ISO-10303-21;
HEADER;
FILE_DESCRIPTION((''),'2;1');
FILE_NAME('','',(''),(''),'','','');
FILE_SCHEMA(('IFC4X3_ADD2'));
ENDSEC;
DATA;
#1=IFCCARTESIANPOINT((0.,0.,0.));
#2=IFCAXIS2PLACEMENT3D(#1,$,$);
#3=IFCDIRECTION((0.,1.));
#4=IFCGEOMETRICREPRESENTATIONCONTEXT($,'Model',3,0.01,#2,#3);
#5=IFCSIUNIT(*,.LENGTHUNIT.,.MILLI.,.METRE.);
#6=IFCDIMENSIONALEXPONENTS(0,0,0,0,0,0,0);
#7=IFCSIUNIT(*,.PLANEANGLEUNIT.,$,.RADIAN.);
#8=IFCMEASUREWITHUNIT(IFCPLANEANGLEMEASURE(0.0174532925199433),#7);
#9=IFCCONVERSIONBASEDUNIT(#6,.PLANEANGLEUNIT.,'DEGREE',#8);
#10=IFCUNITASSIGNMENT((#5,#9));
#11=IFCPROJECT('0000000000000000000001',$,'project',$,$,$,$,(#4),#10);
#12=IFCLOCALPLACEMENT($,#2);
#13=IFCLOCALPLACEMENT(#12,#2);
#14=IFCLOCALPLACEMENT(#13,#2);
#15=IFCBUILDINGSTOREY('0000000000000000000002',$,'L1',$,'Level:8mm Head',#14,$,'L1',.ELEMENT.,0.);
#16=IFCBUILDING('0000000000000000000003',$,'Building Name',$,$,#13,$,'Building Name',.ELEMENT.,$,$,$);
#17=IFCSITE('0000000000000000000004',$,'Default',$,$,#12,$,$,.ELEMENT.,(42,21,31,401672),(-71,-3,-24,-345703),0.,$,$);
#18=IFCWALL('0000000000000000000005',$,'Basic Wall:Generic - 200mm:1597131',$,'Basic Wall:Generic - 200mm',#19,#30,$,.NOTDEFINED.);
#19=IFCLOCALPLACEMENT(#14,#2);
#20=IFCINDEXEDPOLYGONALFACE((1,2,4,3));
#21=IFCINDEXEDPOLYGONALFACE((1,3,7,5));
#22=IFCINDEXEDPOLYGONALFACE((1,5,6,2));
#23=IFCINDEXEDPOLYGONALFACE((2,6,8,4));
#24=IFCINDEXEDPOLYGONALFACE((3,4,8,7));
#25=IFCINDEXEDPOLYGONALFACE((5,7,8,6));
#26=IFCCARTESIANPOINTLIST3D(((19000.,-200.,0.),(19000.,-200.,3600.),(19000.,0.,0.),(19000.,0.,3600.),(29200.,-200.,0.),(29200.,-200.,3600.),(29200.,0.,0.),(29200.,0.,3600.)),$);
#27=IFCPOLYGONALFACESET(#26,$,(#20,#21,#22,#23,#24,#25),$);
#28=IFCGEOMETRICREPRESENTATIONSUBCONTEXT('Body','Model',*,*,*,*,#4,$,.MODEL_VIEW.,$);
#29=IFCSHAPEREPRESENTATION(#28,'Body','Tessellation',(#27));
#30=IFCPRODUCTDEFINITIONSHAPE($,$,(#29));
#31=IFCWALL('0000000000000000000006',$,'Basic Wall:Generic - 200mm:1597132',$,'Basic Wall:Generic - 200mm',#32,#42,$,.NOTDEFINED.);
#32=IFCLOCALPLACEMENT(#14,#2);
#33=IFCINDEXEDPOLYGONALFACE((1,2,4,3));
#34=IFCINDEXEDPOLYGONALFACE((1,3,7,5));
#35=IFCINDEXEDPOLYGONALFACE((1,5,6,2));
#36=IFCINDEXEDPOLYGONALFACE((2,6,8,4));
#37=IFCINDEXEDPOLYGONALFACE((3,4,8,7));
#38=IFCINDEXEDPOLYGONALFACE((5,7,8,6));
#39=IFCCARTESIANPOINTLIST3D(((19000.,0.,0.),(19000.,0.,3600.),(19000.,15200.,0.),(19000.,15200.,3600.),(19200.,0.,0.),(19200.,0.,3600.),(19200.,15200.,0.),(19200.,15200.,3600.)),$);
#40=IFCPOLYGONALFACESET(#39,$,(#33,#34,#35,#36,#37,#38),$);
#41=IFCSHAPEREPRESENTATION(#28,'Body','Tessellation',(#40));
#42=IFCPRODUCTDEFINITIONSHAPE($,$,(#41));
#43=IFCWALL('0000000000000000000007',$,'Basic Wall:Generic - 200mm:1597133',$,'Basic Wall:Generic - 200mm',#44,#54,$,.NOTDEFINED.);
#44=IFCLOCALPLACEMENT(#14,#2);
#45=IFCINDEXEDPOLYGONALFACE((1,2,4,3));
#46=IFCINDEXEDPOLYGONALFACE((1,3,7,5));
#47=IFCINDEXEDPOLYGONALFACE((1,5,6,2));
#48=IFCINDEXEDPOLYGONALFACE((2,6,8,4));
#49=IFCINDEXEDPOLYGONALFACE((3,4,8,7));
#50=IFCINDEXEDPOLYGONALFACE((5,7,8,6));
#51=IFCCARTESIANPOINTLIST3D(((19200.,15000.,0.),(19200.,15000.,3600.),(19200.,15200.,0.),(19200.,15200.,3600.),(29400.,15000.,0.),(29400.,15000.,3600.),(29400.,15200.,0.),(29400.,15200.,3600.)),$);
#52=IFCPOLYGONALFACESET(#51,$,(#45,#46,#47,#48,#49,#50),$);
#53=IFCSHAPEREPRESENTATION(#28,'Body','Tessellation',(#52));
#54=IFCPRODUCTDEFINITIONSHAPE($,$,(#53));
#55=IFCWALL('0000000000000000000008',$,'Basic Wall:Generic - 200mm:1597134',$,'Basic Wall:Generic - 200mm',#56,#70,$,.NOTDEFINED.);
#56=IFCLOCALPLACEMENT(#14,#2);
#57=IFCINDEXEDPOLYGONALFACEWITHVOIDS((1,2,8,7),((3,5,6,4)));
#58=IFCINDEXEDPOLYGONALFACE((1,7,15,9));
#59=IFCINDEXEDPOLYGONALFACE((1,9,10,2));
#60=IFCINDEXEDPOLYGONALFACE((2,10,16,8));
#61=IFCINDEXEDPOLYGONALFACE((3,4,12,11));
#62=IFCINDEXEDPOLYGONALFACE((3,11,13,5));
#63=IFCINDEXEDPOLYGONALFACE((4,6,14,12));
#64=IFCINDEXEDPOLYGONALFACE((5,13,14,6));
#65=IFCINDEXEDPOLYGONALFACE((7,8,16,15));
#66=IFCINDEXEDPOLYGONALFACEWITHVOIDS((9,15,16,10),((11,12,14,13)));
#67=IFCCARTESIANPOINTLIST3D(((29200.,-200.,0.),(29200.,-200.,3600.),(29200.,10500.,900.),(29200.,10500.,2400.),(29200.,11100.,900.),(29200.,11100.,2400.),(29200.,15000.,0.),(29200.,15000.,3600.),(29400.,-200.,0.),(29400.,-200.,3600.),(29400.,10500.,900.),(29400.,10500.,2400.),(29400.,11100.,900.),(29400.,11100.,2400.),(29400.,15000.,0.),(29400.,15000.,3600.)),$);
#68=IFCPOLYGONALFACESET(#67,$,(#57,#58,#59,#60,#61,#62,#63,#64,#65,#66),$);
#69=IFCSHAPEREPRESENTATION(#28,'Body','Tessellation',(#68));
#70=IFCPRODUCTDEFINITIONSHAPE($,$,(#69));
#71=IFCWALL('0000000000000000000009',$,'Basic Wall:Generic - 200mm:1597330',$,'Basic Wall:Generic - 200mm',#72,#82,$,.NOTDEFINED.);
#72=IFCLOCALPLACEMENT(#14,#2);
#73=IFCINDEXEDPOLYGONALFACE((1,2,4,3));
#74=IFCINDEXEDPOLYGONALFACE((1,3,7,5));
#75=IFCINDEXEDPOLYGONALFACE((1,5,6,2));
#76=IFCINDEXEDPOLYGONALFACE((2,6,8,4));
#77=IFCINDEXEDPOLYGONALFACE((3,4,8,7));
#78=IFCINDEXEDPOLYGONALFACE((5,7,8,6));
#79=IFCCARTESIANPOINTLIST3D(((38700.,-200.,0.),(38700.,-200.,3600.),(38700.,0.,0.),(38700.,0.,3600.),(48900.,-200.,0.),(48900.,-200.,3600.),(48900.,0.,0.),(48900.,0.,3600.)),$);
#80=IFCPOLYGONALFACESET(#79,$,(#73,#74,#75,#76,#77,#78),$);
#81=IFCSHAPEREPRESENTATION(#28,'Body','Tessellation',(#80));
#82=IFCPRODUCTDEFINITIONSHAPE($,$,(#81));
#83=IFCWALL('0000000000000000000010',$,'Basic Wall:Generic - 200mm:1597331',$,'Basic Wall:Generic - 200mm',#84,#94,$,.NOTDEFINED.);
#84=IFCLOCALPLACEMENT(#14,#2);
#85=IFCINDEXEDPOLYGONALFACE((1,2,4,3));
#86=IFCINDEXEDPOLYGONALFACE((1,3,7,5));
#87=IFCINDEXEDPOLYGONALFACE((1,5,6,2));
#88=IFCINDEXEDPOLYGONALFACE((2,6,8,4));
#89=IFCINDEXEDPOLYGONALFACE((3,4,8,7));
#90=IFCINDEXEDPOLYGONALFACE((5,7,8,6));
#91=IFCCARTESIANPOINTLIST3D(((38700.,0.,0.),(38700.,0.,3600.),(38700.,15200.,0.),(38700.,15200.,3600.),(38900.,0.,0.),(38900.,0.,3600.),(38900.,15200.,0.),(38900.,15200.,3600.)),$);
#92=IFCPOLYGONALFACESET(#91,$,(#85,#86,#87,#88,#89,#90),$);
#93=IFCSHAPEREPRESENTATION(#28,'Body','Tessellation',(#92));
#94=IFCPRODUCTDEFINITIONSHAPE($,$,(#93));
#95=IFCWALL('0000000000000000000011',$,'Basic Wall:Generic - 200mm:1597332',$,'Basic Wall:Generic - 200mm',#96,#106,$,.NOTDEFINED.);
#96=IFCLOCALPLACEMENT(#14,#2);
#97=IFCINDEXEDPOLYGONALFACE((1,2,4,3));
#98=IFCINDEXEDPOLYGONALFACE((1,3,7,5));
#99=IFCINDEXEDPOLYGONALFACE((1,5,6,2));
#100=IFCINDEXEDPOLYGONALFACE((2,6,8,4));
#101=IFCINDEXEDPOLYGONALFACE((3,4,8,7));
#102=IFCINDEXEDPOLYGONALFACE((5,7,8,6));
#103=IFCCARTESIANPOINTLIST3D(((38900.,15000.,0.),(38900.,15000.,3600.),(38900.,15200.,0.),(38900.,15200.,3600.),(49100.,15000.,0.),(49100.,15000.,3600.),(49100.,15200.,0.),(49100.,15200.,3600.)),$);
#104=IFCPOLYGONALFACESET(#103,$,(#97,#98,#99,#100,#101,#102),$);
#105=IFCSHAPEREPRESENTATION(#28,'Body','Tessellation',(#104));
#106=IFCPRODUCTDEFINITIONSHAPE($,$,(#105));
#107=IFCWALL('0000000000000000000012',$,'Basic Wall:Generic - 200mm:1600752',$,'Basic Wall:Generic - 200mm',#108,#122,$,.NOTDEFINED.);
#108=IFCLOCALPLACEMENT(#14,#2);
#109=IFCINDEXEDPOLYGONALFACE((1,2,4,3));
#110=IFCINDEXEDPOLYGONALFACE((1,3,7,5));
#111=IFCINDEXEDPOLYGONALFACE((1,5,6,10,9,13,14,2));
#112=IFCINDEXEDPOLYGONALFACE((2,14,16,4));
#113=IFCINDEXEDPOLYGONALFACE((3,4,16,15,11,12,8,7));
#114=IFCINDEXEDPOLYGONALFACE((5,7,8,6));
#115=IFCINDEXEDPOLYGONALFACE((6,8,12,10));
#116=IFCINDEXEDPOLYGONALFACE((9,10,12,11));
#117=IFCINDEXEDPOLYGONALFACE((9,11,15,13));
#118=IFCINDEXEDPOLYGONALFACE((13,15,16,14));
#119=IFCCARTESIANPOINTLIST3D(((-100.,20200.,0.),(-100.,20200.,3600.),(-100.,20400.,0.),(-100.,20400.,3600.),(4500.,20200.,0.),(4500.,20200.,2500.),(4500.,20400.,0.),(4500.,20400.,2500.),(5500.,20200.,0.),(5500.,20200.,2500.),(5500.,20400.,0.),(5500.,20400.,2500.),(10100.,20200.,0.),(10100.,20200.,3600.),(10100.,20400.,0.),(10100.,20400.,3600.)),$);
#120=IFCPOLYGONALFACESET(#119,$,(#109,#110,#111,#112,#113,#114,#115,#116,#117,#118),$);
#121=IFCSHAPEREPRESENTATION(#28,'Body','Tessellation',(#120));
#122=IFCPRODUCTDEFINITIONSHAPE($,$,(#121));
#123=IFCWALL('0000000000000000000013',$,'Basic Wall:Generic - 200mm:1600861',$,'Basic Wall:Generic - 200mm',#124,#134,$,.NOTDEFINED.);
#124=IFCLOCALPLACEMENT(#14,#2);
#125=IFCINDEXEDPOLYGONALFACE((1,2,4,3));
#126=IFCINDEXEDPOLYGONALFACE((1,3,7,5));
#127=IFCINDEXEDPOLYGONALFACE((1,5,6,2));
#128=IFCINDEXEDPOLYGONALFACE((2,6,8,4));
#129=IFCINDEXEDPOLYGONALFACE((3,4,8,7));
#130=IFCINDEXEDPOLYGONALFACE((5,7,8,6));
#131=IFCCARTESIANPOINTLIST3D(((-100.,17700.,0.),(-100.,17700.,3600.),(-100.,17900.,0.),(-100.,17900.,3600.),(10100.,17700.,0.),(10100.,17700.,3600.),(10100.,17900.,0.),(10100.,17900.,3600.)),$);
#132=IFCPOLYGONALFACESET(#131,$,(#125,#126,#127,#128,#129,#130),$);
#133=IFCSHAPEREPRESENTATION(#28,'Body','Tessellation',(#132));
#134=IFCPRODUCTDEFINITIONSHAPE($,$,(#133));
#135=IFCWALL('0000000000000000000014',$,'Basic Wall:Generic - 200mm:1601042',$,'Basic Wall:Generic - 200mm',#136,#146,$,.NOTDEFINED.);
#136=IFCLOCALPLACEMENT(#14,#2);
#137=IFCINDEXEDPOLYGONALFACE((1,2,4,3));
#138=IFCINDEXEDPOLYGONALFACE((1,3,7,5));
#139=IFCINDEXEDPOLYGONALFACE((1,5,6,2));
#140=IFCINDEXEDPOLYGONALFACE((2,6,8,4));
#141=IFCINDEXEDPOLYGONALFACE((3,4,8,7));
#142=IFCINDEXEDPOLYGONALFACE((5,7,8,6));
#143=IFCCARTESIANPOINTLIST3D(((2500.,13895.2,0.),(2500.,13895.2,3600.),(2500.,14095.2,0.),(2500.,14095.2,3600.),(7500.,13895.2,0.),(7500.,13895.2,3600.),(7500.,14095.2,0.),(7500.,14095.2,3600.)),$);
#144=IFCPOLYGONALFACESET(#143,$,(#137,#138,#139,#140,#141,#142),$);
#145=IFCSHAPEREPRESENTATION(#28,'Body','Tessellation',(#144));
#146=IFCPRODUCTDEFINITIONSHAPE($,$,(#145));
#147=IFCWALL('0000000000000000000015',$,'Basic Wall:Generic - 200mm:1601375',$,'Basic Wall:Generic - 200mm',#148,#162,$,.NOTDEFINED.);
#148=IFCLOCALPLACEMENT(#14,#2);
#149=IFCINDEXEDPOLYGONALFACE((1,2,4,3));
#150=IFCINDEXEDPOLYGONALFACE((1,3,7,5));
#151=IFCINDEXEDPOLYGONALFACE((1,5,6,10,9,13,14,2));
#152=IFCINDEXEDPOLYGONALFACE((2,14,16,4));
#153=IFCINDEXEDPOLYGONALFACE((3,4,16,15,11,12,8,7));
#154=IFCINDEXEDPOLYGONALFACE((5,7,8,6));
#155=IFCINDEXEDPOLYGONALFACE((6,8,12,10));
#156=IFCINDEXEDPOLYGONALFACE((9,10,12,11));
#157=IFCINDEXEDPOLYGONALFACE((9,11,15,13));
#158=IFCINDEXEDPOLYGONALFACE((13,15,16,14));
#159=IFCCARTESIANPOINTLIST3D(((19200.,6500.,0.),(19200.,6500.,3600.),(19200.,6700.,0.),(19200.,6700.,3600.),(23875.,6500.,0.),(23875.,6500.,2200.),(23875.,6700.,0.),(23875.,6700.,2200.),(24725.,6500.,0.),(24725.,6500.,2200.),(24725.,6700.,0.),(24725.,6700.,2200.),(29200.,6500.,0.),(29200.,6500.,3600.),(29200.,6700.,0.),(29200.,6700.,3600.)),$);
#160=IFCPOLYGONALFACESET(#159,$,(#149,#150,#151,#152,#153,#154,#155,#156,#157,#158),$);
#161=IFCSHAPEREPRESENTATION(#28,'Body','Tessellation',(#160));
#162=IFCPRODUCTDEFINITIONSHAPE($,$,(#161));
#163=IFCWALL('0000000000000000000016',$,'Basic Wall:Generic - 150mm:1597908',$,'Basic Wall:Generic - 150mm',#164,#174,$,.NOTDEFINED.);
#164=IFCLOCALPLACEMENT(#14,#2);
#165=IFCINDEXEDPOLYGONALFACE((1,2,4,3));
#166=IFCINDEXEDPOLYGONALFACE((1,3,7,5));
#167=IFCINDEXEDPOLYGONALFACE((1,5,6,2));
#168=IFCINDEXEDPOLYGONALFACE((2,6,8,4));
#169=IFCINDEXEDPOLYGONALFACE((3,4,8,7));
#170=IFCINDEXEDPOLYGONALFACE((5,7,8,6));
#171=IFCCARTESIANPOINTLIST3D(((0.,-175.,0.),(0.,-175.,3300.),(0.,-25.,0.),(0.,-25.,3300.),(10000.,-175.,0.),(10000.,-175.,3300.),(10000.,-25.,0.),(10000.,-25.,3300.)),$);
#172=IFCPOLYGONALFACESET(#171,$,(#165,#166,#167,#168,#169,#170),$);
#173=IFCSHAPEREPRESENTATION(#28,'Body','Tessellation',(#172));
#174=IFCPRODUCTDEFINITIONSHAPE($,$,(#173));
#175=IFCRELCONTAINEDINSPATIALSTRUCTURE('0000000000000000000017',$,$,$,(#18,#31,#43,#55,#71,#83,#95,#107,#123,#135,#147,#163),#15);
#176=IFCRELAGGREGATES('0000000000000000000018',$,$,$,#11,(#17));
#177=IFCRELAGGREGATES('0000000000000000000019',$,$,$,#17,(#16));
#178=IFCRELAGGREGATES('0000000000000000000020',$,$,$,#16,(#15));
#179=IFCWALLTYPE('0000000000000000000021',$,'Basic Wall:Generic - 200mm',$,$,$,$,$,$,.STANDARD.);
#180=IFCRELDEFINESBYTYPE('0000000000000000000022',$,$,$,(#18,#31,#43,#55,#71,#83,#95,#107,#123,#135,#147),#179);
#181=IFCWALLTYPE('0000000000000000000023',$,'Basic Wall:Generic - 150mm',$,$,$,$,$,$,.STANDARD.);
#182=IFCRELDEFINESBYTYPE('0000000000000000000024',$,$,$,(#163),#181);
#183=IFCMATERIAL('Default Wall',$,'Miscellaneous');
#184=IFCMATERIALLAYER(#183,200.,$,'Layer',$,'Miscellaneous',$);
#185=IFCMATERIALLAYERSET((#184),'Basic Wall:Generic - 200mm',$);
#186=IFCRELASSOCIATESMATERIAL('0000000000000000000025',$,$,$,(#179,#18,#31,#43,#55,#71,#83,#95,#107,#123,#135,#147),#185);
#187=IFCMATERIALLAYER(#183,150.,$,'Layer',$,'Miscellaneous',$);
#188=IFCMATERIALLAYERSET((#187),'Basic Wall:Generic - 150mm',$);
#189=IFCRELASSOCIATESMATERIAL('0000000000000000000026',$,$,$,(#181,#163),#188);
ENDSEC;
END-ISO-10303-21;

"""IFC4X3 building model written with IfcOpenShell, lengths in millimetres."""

from ifc_helpers import new_model, entity, si_unit, converted_unit, direction, frame, frame_2d, origin, origin_2d_with_axis, place, context, subcontext, project, spatial, rectangle, extrude, material, layer, layer_set, type_object, element, save


model = new_model("IFC4X3")

# Units and contexts
model_context = context("Model", 3, precision=0.01, world=origin(), true_north=direction((0.0, 1.0)))
body_context = subcontext(model_context, "Body", "Model", "MODEL_VIEW")
ifc_project = project(units=[si_unit("LENGTHUNIT", "METRE", prefix="MILLI"), converted_unit("PLANEANGLEUNIT", "DEGREE", entity("IfcPlaneAngleMeasure", 0.0174532925199433), si_unit("PLANEANGLEUNIT", "RADIAN"), dimensions=[0, 0, 0, 0, 0, 0, 0])], contexts=[model_context])

# Site, building, storey
site_placement = place(None, origin())
site = spatial("IfcSite", under=ifc_project, at=site_placement, Name="Default", CompositionType="ELEMENT", RefLatitude=(42, 21, 31, 401672), RefLongitude=(-71, -3, -24, -345703), RefElevation=0.0)
building_placement = place(site_placement, origin())
building = spatial("IfcBuilding", under=site, at=building_placement, Name="Building Name", LongName="Building Name", CompositionType="ELEMENT")
storey_placement = place(building_placement, origin())
storey = spatial("IfcBuildingStorey", under=building, at=storey_placement, Name="L1", ObjectType="Level:8mm Head", LongName="L1", CompositionType="ELEMENT", Elevation=0.0)

# Walls
ifc_material_1 = material(Name="Default Wall", Category="Miscellaneous")
ifc_layer_1 = layer(ifc_material_1, 200.0, Name="Layer", Category="Miscellaneous")
ifc_layer_set_1 = layer_set([ifc_layer_1], Name="Basic Wall:Generic - 200mm")
wall_type_1 = type_object("IfcWallType", Name="Basic Wall:Generic - 200mm", PredefinedType="STANDARD", material=ifc_layer_set_1)
wall_1_placement = place(storey_placement, frame((19000.0, -100.0, 0.0)))
element("IfcWall", 1, at=wall_1_placement, inside=storey, type_object=wall_type_1, material=ifc_layer_set_1, Name="Basic Wall:Generic - 200mm:1597131", ObjectType="Basic Wall:Generic - 200mm", PredefinedType="NOTDEFINED", context=body_context, shape_type="SweptSolid", body=[
    extrude(rectangle(XDim=10200.0, YDim=200.0, at=frame_2d((5100.0, 0.0), x_axis=(-1.0, 0.0))), origin(), (0.0, 0.0, 1.0), 3600.0),
])
wall_2_placement = place(storey_placement, frame((19100.0, 15200.0, 0.0), z_axis=(0.0, 0.0, 1.0), x_axis=(0.0, -1.0, 0.0)))
element("IfcWall", 2, at=wall_2_placement, inside=storey, type_object=wall_type_1, material=ifc_layer_set_1, Name="Basic Wall:Generic - 200mm:1597132", ObjectType="Basic Wall:Generic - 200mm", PredefinedType="NOTDEFINED", context=body_context, shape_type="SweptSolid", body=[
    extrude(rectangle(XDim=15200.0, YDim=200.0, at=frame_2d((7600.0, 0.0), x_axis=(-1.0, 0.0))), origin(), (0.0, 0.0, 1.0), 3600.0),
])
wall_3_placement = place(storey_placement, frame((29400.0, 15100.0, 0.0), z_axis=(0.0, 0.0, 1.0), x_axis=(-1.0, 0.0, 0.0)))
element("IfcWall", 3, at=wall_3_placement, inside=storey, type_object=wall_type_1, material=ifc_layer_set_1, Name="Basic Wall:Generic - 200mm:1597133", ObjectType="Basic Wall:Generic - 200mm", PredefinedType="NOTDEFINED", context=body_context, shape_type="SweptSolid", body=[
    extrude(rectangle(XDim=10200.0, YDim=200.0, at=frame_2d((5100.0, 0.0), x_axis=(-1.0, 0.0))), origin(), (0.0, 0.0, 1.0), 3600.0),
])

# Wall, opening
wall_4_placement = place(storey_placement, frame((29300.0, -200.0, 0.0), z_axis=(0.0, 0.0, 1.0), x_axis=(0.0, 1.0, 0.0)))
wall_4 = element("IfcWall", 4, at=wall_4_placement, inside=storey, type_object=wall_type_1, material=ifc_layer_set_1, Name="Basic Wall:Generic - 200mm:1597134", ObjectType="Basic Wall:Generic - 200mm", PredefinedType="NOTDEFINED", context=body_context, shape_type="SweptSolid", body=[
    extrude(rectangle(XDim=15200.0, YDim=200.0, at=frame_2d((7600.0, 0.0), x_axis=(-1.0, 0.0))), origin(), (0.0, 0.0, 1.0), 3600.0),
])
opening_1_placement = place(wall_4_placement, frame((11300.0, 100.0, 900.0)))
element("IfcOpeningElement", 5, at=opening_1_placement, cuts=wall_4, PredefinedType="OPENING", context=body_context, shape_type="SweptSolid", body=[
    extrude(rectangle(XDim=1500.0, YDim=600.0, at=frame_2d((750.0, 300.0), x_axis=(-1.0, 0.0))), frame((0.0, 0.0, 0.0), z_axis=(0.0, -1.0, 0.0), x_axis=(0.0, 0.0, 1.0)), (0.0, 0.0, 1.0), 200.0),
])

# Walls
wall_5_placement = place(storey_placement, frame((38700.0, -100.0, 0.0)))
element("IfcWall", 6, at=wall_5_placement, inside=storey, type_object=wall_type_1, material=ifc_layer_set_1, Name="Basic Wall:Generic - 200mm:1597330", ObjectType="Basic Wall:Generic - 200mm", PredefinedType="NOTDEFINED", context=body_context, shape_type="SweptSolid", body=[
    extrude(rectangle(XDim=10200.0, YDim=200.0, at=frame_2d((5100.0, 0.0), x_axis=(-1.0, 0.0))), origin(), (0.0, 0.0, 1.0), 3600.0),
])
wall_6_placement = place(storey_placement, frame((38800.0, 15200.0, 0.0), z_axis=(0.0, 0.0, 1.0), x_axis=(0.0, -1.0, 0.0)))
element("IfcWall", 7, at=wall_6_placement, inside=storey, type_object=wall_type_1, material=ifc_layer_set_1, Name="Basic Wall:Generic - 200mm:1597331", ObjectType="Basic Wall:Generic - 200mm", PredefinedType="NOTDEFINED", context=body_context, shape_type="SweptSolid", body=[
    extrude(rectangle(XDim=15200.0, YDim=200.0, at=frame_2d((7600.0, 0.0), x_axis=(-1.0, 0.0))), origin(), (0.0, 0.0, 1.0), 3600.0),
])
wall_7_placement = place(storey_placement, frame((49100.0, 15100.0, 0.0), z_axis=(0.0, 0.0, 1.0), x_axis=(-1.0, 0.0, 0.0)))
element("IfcWall", 8, at=wall_7_placement, inside=storey, type_object=wall_type_1, material=ifc_layer_set_1, Name="Basic Wall:Generic - 200mm:1597332", ObjectType="Basic Wall:Generic - 200mm", PredefinedType="NOTDEFINED", context=body_context, shape_type="SweptSolid", body=[
    extrude(rectangle(XDim=10200.0, YDim=200.0, at=frame_2d((5100.0, 0.0), x_axis=(-1.0, 0.0))), origin(), (0.0, 0.0, 1.0), 3600.0),
])

# Wall, opening
wall_8_placement = place(storey_placement, frame((10100.0, 20300.0, 0.0), z_axis=(0.0, 0.0, 1.0), x_axis=(-1.0, 0.0, 0.0)))
wall_8 = element("IfcWall", 9, at=wall_8_placement, inside=storey, type_object=wall_type_1, material=ifc_layer_set_1, Name="Basic Wall:Generic - 200mm:1600752", ObjectType="Basic Wall:Generic - 200mm", PredefinedType="NOTDEFINED", context=body_context, shape_type="SweptSolid", body=[
    extrude(rectangle(XDim=10200.0, YDim=200.0, at=frame_2d((5100.0, 0.0), x_axis=(1.0, 0.0))), origin(), (0.0, 0.0, 1.0), 3600.0),
])
opening_2_placement = place(wall_8_placement, frame((5600.0, 100.0, 0.0)))
element("IfcOpeningElement", 10, at=opening_2_placement, cuts=wall_8, PredefinedType="OPENING", context=body_context, shape_type="SweptSolid", body=[
    extrude(rectangle(XDim=2500.0, YDim=1000.0, at=origin_2d_with_axis()), frame((-500.0, -200.0, 1250.0), z_axis=(0.0, 1.0, 0.0), x_axis=(0.0, 0.0, -1.0)), (0.0, 0.0, 1.0), 200.0),
])

# Walls
wall_9_placement = place(storey_placement, frame((10100.0, 17800.0, 0.0), z_axis=(0.0, 0.0, 1.0), x_axis=(-1.0, 0.0, 0.0)))
element("IfcWall", 11, at=wall_9_placement, inside=storey, type_object=wall_type_1, material=ifc_layer_set_1, Name="Basic Wall:Generic - 200mm:1600861", ObjectType="Basic Wall:Generic - 200mm", PredefinedType="NOTDEFINED", context=body_context, shape_type="SweptSolid", body=[
    extrude(rectangle(XDim=10200.0, YDim=200.0, at=frame_2d((5100.0, 0.0), x_axis=(-1.0, 0.0))), origin(), (0.0, 0.0, 1.0), 3600.0),
])
wall_10_placement = place(storey_placement, frame((7500.0, 13995.2, 0.0), z_axis=(0.0, 0.0, 1.0), x_axis=(-1.0, 0.0, 0.0)))
element("IfcWall", 12, at=wall_10_placement, inside=storey, type_object=wall_type_1, material=ifc_layer_set_1, Name="Basic Wall:Generic - 200mm:1601042", ObjectType="Basic Wall:Generic - 200mm", PredefinedType="NOTDEFINED", context=body_context, shape_type="SweptSolid", body=[
    extrude(rectangle(XDim=5000.0, YDim=200.0, at=frame_2d((2500.0, 0.0), x_axis=(-1.0, 0.0))), origin(), (0.0, 0.0, 1.0), 3600.0),
])

# Wall, opening
wall_11_placement = place(storey_placement, frame((29200.0, 6600.0, 0.0), z_axis=(0.0, 0.0, 1.0), x_axis=(-1.0, 0.0, 0.0)))
wall_11 = element("IfcWall", 13, at=wall_11_placement, inside=storey, type_object=wall_type_1, material=ifc_layer_set_1, Name="Basic Wall:Generic - 200mm:1601375", ObjectType="Basic Wall:Generic - 200mm", PredefinedType="NOTDEFINED", context=body_context, shape_type="SweptSolid", body=[
    extrude(rectangle(XDim=10000.0, YDim=200.0, at=frame_2d((5000.0, 0.0), x_axis=(1.0, 0.0))), origin(), (0.0, 0.0, 1.0), 3600.0),
])
opening_3_placement = place(wall_11_placement, frame((5325.0, 100.0, 0.0)))
element("IfcOpeningElement", 14, at=opening_3_placement, cuts=wall_11, PredefinedType="OPENING", context=body_context, shape_type="SweptSolid", body=[
    extrude(rectangle(XDim=2200.0, YDim=850.0, at=frame_2d((1100.0, 425.0), x_axis=(1.0, 0.0))), frame((0.0, 0.0, 0.0), z_axis=(0.0, -1.0, 0.0), x_axis=(0.0, 0.0, 1.0)), (0.0, 0.0, 1.0), 200.0),
])

# Wall
ifc_layer_2 = layer(ifc_material_1, 150.0, Name="Layer", Category="Miscellaneous")
ifc_layer_set_2 = layer_set([ifc_layer_2], Name="Basic Wall:Generic - 150mm")
wall_type_2 = type_object("IfcWallType", Name="Basic Wall:Generic - 150mm", PredefinedType="STANDARD", material=ifc_layer_set_2)
wall_12_placement = place(storey_placement, frame((0.0, -100.0, 0.0)))
element("IfcWall", 15, at=wall_12_placement, inside=storey, type_object=wall_type_2, material=ifc_layer_set_2, Name="Basic Wall:Generic - 150mm:1597908", ObjectType="Basic Wall:Generic - 150mm", PredefinedType="NOTDEFINED", context=body_context, shape_type="SweptSolid", body=[
    extrude(rectangle(XDim=10000.0, YDim=150.0, at=frame_2d((5000.0, 0.0), x_axis=(-1.0, 0.0))), origin(), (0.0, 0.0, 1.0), 3300.0),
])

save(model, "model.ifc")
